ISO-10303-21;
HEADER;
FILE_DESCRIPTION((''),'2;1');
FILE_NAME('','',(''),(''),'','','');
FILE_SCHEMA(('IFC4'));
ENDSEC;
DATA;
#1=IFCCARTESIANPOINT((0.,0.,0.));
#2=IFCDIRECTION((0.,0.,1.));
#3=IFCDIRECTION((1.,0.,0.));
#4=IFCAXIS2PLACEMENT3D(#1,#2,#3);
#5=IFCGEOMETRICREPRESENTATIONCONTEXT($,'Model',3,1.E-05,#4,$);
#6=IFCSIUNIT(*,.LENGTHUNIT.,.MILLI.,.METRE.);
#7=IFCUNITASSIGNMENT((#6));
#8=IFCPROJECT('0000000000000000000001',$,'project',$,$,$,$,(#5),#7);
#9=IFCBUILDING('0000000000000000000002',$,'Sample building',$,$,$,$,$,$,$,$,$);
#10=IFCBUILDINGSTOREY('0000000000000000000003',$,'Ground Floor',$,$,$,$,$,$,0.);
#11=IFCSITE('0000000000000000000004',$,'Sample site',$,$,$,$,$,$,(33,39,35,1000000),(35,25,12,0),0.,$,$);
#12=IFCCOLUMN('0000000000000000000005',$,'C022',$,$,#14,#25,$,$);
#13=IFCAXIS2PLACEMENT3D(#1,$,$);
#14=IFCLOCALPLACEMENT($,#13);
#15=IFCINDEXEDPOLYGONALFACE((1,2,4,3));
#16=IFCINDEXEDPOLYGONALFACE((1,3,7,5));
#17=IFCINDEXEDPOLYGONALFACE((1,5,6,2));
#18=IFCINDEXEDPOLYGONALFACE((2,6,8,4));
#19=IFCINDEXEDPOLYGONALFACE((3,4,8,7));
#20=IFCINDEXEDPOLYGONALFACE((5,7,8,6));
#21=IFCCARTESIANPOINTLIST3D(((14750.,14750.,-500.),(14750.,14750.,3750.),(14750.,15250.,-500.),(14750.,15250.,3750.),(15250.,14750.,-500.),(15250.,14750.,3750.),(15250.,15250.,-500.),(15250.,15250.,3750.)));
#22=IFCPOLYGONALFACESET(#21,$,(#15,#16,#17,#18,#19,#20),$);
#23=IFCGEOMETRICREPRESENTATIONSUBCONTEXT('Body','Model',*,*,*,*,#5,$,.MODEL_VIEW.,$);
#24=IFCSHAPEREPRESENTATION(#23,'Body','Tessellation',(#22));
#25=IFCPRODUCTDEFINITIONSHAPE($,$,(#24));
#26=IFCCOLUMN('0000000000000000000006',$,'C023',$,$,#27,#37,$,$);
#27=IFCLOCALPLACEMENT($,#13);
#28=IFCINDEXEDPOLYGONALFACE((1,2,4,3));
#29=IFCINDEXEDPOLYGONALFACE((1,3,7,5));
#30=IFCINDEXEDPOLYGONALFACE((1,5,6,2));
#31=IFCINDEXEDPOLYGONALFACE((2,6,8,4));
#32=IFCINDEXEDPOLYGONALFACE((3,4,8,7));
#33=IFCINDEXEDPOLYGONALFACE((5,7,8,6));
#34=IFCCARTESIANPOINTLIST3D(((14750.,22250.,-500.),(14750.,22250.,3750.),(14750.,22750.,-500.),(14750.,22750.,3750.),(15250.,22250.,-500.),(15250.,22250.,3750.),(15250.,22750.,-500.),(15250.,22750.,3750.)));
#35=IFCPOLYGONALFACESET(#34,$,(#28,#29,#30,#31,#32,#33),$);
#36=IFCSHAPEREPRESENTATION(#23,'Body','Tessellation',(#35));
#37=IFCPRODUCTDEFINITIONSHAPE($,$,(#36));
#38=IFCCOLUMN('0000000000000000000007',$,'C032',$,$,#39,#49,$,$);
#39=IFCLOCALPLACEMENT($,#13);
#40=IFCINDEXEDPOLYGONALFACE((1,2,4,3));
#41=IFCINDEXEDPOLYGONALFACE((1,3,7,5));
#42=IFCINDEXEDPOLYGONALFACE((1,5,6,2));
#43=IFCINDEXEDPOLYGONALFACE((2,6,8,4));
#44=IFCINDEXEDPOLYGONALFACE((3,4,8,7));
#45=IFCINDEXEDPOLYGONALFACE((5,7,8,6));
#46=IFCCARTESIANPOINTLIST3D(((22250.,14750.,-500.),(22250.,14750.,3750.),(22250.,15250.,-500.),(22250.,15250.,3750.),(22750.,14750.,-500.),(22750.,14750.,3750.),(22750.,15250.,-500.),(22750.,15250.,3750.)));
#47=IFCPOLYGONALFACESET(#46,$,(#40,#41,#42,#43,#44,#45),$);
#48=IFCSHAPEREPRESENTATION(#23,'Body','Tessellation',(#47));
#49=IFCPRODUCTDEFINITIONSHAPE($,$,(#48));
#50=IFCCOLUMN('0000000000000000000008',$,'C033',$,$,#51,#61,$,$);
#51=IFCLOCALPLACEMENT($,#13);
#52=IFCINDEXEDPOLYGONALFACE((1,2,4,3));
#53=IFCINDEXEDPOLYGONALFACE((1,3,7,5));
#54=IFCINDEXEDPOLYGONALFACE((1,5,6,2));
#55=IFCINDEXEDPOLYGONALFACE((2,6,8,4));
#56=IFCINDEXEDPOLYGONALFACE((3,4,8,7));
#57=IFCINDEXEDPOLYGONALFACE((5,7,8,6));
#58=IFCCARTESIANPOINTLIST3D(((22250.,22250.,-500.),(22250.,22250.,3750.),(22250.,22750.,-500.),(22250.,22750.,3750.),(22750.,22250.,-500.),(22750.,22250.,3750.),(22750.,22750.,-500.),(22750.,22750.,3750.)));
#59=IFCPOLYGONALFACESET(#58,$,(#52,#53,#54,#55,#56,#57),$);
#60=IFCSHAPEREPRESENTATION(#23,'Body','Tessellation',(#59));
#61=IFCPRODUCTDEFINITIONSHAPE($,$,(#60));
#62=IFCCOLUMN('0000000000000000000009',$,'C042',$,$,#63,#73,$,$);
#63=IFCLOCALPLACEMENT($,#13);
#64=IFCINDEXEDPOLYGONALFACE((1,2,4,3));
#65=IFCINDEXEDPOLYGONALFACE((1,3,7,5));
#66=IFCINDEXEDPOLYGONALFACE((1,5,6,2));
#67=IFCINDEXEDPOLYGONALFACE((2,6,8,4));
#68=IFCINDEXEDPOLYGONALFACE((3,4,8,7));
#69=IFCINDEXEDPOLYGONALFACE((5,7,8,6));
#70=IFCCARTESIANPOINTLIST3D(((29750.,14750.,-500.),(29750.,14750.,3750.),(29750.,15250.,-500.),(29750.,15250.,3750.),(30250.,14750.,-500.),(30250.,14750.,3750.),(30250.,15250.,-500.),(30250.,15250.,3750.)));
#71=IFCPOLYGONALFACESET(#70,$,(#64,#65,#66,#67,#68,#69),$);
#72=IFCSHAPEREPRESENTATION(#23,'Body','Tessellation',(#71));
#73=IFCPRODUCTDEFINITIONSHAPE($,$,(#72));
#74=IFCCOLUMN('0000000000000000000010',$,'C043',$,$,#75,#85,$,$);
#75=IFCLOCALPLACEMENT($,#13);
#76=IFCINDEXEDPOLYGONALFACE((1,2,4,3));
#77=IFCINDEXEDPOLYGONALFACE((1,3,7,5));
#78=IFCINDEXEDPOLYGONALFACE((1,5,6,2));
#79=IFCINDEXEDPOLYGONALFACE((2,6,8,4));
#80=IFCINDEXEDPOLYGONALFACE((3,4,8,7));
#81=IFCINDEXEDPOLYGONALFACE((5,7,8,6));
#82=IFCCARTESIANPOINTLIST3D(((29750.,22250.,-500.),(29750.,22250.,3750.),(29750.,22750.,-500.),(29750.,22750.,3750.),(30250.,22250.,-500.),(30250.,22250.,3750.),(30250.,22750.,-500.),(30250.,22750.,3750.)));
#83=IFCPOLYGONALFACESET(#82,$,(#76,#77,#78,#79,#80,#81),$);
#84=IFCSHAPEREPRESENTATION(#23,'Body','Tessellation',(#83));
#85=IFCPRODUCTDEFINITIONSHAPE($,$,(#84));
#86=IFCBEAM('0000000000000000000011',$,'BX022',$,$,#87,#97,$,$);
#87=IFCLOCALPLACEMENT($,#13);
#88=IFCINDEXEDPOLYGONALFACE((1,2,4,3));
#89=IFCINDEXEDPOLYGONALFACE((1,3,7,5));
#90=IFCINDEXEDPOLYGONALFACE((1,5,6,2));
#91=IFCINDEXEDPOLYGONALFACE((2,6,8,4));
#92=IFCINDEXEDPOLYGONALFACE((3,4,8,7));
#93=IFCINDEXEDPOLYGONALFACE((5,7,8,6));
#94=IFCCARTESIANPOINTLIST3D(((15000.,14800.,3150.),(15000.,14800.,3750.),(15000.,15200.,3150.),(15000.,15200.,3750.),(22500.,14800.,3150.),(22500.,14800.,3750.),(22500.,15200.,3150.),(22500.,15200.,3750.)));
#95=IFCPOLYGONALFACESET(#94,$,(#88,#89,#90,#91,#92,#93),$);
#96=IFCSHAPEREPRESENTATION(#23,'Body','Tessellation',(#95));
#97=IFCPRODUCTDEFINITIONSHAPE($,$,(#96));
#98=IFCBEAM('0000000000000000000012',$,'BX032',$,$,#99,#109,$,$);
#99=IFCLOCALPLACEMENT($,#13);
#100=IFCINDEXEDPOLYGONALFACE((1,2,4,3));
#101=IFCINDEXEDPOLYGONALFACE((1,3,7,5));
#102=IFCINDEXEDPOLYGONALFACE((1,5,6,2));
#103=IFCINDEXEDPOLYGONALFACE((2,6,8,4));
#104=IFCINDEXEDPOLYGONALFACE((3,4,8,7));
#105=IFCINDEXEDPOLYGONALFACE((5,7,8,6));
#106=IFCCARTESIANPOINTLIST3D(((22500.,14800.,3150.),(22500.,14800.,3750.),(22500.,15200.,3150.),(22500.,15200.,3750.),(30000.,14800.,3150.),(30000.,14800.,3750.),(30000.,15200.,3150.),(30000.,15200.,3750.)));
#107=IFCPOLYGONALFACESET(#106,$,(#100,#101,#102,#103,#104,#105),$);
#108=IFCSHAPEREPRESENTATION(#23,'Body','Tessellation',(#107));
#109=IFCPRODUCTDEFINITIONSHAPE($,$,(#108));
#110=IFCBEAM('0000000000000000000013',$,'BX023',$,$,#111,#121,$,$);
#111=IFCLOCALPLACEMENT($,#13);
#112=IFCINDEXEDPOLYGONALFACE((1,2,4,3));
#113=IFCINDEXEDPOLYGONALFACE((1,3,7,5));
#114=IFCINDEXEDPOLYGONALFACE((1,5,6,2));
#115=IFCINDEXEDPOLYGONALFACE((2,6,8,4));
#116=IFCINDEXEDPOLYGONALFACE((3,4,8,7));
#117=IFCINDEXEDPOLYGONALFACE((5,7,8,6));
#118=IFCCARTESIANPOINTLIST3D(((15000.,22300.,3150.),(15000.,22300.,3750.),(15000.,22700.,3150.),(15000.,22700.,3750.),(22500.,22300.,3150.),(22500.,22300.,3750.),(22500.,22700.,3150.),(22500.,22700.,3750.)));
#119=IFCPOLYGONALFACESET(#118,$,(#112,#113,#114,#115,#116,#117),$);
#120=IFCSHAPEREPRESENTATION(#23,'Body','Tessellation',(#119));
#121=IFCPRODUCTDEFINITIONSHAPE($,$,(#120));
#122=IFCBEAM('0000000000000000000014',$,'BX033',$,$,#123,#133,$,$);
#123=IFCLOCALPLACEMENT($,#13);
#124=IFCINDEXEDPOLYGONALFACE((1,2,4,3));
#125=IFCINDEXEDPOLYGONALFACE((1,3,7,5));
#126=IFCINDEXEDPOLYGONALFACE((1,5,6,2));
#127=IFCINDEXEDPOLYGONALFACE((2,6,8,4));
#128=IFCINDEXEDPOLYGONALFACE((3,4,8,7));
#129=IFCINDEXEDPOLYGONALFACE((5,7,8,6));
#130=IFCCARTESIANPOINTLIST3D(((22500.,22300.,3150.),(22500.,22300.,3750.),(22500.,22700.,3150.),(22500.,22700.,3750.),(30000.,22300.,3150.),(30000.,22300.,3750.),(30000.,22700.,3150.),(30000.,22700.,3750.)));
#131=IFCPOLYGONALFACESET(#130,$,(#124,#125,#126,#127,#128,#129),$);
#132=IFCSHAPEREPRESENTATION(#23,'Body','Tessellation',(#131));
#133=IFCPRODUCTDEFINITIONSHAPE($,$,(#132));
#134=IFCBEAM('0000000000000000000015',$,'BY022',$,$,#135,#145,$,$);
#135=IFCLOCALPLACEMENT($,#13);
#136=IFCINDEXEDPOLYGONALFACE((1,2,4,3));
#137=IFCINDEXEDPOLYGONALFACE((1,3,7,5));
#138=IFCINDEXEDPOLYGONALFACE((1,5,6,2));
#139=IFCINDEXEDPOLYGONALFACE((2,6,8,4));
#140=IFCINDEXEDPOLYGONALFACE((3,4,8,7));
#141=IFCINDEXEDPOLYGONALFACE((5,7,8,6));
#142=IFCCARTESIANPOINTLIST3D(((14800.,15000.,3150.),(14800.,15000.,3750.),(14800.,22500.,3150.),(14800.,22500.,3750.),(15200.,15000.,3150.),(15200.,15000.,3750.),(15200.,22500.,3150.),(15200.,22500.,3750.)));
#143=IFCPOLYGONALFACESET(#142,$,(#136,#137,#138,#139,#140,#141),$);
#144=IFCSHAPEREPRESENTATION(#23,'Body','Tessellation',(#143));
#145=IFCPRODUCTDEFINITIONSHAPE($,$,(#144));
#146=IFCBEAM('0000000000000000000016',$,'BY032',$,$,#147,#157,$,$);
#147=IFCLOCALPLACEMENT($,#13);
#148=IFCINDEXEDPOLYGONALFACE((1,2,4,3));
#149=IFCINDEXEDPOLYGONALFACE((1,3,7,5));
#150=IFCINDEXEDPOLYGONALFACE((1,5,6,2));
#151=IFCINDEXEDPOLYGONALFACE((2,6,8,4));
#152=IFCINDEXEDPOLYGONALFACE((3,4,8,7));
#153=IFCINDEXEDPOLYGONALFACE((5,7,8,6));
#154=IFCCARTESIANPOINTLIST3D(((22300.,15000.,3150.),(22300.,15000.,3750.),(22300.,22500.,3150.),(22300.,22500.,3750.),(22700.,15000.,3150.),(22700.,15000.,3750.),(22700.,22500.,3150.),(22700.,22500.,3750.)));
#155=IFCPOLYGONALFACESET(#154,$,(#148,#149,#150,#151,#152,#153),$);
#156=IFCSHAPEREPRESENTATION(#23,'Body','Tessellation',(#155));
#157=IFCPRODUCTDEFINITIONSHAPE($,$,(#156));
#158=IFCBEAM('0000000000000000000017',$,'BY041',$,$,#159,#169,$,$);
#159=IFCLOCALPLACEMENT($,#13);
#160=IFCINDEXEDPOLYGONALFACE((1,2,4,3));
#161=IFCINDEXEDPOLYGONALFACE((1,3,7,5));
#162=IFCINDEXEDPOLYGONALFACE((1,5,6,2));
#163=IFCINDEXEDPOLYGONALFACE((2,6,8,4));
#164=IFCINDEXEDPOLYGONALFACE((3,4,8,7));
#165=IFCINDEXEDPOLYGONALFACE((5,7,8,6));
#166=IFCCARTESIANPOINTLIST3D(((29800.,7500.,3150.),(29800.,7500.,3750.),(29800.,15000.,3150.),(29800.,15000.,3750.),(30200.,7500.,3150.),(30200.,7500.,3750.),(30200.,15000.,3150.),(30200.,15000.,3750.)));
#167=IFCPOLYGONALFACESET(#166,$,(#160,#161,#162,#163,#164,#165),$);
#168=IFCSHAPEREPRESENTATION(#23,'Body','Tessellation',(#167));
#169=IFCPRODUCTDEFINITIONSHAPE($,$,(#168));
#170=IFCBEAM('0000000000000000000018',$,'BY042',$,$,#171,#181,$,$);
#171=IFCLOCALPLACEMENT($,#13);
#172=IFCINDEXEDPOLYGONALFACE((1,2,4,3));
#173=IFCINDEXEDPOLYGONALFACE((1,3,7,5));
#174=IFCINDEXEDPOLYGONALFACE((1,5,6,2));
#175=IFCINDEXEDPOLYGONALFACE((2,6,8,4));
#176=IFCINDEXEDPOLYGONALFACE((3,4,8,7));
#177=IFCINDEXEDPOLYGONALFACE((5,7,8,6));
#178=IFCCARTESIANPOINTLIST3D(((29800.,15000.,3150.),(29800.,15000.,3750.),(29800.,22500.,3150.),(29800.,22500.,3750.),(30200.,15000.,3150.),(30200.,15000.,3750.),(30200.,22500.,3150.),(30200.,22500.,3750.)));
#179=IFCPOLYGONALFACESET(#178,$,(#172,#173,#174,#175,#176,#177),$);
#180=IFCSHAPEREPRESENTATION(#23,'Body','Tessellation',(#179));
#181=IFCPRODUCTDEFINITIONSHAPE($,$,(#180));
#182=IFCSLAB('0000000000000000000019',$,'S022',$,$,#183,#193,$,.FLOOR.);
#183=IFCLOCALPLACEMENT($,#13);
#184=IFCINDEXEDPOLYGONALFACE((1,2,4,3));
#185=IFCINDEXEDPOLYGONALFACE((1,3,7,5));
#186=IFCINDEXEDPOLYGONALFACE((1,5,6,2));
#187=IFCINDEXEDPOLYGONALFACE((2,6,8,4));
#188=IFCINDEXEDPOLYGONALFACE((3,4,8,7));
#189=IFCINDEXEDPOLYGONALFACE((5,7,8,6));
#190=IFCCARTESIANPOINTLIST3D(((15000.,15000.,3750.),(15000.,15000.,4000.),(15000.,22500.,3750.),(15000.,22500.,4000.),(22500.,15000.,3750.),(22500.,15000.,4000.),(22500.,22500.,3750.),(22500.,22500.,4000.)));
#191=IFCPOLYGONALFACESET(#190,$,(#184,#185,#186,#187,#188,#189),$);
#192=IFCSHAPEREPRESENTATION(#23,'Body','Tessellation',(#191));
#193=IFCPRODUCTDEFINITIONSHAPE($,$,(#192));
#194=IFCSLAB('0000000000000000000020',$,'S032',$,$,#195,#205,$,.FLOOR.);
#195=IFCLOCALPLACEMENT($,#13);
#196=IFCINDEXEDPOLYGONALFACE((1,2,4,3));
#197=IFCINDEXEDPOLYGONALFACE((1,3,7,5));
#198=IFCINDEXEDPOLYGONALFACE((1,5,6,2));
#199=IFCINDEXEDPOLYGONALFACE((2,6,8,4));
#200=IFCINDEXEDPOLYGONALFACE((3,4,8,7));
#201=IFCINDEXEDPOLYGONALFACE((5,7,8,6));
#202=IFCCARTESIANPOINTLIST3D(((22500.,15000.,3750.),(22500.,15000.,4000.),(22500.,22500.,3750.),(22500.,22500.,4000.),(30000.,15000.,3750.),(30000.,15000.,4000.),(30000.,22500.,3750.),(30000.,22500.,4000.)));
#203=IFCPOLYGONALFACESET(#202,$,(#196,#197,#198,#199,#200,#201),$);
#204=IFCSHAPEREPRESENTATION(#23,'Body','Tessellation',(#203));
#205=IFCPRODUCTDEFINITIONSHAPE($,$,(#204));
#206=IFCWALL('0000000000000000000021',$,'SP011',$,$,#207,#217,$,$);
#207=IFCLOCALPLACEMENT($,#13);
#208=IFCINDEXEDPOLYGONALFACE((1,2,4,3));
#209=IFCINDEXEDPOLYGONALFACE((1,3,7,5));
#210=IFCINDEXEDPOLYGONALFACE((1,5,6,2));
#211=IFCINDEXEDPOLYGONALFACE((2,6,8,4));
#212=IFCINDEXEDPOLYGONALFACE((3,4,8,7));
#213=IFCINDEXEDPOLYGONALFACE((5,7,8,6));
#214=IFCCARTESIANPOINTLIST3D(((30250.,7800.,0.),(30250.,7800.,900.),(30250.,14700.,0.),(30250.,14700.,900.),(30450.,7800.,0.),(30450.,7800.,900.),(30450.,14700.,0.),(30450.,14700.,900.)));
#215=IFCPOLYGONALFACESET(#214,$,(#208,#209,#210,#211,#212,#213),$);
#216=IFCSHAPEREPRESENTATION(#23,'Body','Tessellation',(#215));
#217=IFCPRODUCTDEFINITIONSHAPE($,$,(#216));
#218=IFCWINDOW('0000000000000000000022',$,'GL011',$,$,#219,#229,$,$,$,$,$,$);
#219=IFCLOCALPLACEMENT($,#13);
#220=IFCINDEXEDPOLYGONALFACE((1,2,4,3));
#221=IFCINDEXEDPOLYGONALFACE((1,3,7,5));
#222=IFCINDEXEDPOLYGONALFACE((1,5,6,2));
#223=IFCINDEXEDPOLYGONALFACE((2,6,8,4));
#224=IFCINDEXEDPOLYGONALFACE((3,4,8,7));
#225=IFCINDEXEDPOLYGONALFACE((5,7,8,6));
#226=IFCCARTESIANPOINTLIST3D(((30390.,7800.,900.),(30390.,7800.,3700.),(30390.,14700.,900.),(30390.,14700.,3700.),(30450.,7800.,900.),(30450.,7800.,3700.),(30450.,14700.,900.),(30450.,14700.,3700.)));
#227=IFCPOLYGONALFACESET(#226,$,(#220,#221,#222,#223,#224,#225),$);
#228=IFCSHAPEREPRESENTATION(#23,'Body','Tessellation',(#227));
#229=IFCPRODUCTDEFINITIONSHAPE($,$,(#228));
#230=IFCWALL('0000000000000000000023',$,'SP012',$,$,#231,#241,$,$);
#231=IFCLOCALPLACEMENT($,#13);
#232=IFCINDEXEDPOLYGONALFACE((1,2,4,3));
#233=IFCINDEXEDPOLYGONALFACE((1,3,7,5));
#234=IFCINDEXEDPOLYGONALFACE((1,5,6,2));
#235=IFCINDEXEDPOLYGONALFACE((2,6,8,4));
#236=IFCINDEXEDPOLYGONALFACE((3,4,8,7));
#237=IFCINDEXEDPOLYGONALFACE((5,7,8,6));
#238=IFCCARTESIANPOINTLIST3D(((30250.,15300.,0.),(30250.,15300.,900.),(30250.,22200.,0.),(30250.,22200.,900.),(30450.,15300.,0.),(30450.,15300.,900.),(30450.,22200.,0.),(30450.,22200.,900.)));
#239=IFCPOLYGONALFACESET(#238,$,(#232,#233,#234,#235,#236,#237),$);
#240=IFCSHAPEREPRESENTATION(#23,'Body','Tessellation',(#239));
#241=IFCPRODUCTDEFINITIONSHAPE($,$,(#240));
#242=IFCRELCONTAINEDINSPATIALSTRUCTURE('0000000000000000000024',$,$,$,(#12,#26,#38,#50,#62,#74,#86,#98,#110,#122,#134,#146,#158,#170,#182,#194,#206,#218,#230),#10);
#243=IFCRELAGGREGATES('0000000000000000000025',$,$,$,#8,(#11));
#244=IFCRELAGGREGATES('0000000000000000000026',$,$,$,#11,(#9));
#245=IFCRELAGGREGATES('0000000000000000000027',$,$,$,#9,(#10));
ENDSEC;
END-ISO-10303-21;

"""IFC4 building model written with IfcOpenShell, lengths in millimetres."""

from ifc_helpers import new_model, si_unit, frame, origin_with_axes, place, context, subcontext, project, spatial, indexed_curve, outline, extrude, element, save


model = new_model("IFC4")

# Units and contexts
model_context = context("Model", 3, precision=1e-05, world=origin_with_axes())
body_context = subcontext(model_context, "Body", "Model", "MODEL_VIEW")
ifc_project = project(units=[si_unit("LENGTHUNIT", "METRE", prefix="MILLI")], contexts=[model_context])

# Site, building, storey
site = spatial("IfcSite", under=ifc_project, Name="Sample site", RefLatitude=(33, 39, 35, 1000000), RefLongitude=(35, 25, 12, 0), RefElevation=0.0)
building = spatial("IfcBuilding", under=site, Name="Sample building")
storey = spatial("IfcBuildingStorey", under=building, Name="Ground Floor", Elevation=0.0)

# Columns
for number, where, z_axis, x_axis, name in (
    (1, (14750.0, 14750.0, -500.0), (0.0, 0.0, 1.0), (1.0, 0.0, 0.0), "C022"),
    (2, (14750.0, 22250.0, -500.0), (0.0, 0.0, 1.0), (1.0, 0.0, 0.0), "C023"),
    (3, (22250.0, 14750.0, -500.0), (0.0, 0.0, 1.0), (1.0, 0.0, 0.0), "C032"),
    (4, (22250.0, 22250.0, -500.0), (0.0, 0.0, 1.0), (1.0, 0.0, 0.0), "C033"),
    (5, (29750.0, 14750.0, -500.0), (0.0, 0.0, 1.0), (1.0, 0.0, 0.0), "C042"),
    (6, (29750.0, 22250.0, -500.0), (0.0, 0.0, 1.0), (1.0, 0.0, 0.0), "C043"),
):
    element("IfcColumn", number, at=place(None, frame(where, z_axis=z_axis, x_axis=x_axis)), inside=storey, Name=name, context=body_context, shape_type="SweptSolid", body=[
        extrude(outline(indexed_curve([(0.0, 0.0), (0.0, 500.0), (500.0, 500.0), (500.0, 0.0), (0.0, 0.0)], self_intersect=False)), origin_with_axes(), (0.0, 0.0, 1.0), 4250.0),
    ])

# Beams
for number, where, z_axis, x_axis, name in (
    (7, (15000.0, 14800.0, 3150.0), (0.0, 0.0, 1.0), (1.0, 0.0, 0.0), "BX022"),
    (8, (22500.0, 14800.0, 3150.0), (0.0, 0.0, 1.0), (1.0, 0.0, 0.0), "BX032"),
    (9, (15000.0, 22300.0, 3150.0), (0.0, 0.0, 1.0), (1.0, 0.0, 0.0), "BX023"),
    (10, (22500.0, 22300.0, 3150.0), (0.0, 0.0, 1.0), (1.0, 0.0, 0.0), "BX033"),
    (11, (15200.0, 15000.0, 3150.0), (0.0, 0.0, 1.0), (0.0, 1.0, 0.0), "BY022"),
    (12, (22700.0, 15000.0, 3150.0), (0.0, 0.0, 1.0), (0.0, 1.0, 0.0), "BY032"),
    (13, (30200.0, 7500.0, 3150.0), (0.0, 0.0, 1.0), (0.0, 1.0, 0.0), "BY041"),
    (14, (30200.0, 15000.0, 3150.0), (0.0, 0.0, 1.0), (0.0, 1.0, 0.0), "BY042"),
):
    element("IfcBeam", number, at=place(None, frame(where, z_axis=z_axis, x_axis=x_axis)), inside=storey, Name=name, context=body_context, shape_type="SweptSolid", body=[
        extrude(outline(indexed_curve([(0.0, 0.0), (0.0, 400.0), (7500.0, 400.0), (7500.0, 0.0), (0.0, 0.0)], self_intersect=False)), origin_with_axes(), (0.0, 0.0, 1.0), 600.0),
    ])

# Slabs
for number, where, z_axis, x_axis, name in (
    (15, (15000.0, 15000.0, 3750.0), (0.0, 0.0, 1.0), (1.0, 0.0, 0.0), "S022"),
    (16, (22500.0, 15000.0, 3750.0), (0.0, 0.0, 1.0), (1.0, 0.0, 0.0), "S032"),
):
    element("IfcSlab", number, at=place(None, frame(where, z_axis=z_axis, x_axis=x_axis)), inside=storey, Name=name, PredefinedType="FLOOR", context=body_context, shape_type="SweptSolid", body=[
        extrude(outline(indexed_curve([(0.0, 0.0), (0.0, 7500.0), (7500.0, 7500.0), (7500.0, 0.0), (0.0, 0.0)], self_intersect=False)), origin_with_axes(), (0.0, 0.0, 1.0), 250.0),
    ])

# Wall
wall_1_placement = place(None, frame((30450.0, 7800.0, 0.0), z_axis=(0.0, 0.0, 1.0), x_axis=(0.0, 1.0, 0.0)))
element("IfcWall", 17, at=wall_1_placement, inside=storey, Name="SP011", context=body_context, shape_type="SweptSolid", body=[
    extrude(outline(indexed_curve([(0.0, 0.0), (0.0, 200.0), (6900.0, 200.0), (6900.0, 0.0), (0.0, 0.0)], self_intersect=False)), origin_with_axes(), (0.0, 0.0, 1.0), 900.0),
])

# Window
window_1_placement = place(None, frame((30450.0, 7800.0, 900.0), z_axis=(0.0, 0.0, 1.0), x_axis=(0.0, 1.0, 0.0)))
element("IfcWindow", 18, at=window_1_placement, inside=storey, Name="GL011", context=body_context, shape_type="SweptSolid", body=[
    extrude(outline(indexed_curve([(0.0, 0.0), (0.0, 60.0), (6900.0, 60.0), (6900.0, 0.0), (0.0, 0.0)], self_intersect=False)), origin_with_axes(), (0.0, 0.0, 1.0), 2800.0),
])

# Wall
wall_2_placement = place(None, frame((30450.0, 15300.0, 0.0), z_axis=(0.0, 0.0, 1.0), x_axis=(0.0, 1.0, 0.0)))
element("IfcWall", 19, at=wall_2_placement, inside=storey, Name="SP012", context=body_context, shape_type="SweptSolid", body=[
    extrude(outline(indexed_curve([(0.0, 0.0), (0.0, 200.0), (6900.0, 200.0), (6900.0, 0.0), (0.0, 0.0)], self_intersect=False)), origin_with_axes(), (0.0, 0.0, 1.0), 900.0),
])

save(model, "model.ifc")
